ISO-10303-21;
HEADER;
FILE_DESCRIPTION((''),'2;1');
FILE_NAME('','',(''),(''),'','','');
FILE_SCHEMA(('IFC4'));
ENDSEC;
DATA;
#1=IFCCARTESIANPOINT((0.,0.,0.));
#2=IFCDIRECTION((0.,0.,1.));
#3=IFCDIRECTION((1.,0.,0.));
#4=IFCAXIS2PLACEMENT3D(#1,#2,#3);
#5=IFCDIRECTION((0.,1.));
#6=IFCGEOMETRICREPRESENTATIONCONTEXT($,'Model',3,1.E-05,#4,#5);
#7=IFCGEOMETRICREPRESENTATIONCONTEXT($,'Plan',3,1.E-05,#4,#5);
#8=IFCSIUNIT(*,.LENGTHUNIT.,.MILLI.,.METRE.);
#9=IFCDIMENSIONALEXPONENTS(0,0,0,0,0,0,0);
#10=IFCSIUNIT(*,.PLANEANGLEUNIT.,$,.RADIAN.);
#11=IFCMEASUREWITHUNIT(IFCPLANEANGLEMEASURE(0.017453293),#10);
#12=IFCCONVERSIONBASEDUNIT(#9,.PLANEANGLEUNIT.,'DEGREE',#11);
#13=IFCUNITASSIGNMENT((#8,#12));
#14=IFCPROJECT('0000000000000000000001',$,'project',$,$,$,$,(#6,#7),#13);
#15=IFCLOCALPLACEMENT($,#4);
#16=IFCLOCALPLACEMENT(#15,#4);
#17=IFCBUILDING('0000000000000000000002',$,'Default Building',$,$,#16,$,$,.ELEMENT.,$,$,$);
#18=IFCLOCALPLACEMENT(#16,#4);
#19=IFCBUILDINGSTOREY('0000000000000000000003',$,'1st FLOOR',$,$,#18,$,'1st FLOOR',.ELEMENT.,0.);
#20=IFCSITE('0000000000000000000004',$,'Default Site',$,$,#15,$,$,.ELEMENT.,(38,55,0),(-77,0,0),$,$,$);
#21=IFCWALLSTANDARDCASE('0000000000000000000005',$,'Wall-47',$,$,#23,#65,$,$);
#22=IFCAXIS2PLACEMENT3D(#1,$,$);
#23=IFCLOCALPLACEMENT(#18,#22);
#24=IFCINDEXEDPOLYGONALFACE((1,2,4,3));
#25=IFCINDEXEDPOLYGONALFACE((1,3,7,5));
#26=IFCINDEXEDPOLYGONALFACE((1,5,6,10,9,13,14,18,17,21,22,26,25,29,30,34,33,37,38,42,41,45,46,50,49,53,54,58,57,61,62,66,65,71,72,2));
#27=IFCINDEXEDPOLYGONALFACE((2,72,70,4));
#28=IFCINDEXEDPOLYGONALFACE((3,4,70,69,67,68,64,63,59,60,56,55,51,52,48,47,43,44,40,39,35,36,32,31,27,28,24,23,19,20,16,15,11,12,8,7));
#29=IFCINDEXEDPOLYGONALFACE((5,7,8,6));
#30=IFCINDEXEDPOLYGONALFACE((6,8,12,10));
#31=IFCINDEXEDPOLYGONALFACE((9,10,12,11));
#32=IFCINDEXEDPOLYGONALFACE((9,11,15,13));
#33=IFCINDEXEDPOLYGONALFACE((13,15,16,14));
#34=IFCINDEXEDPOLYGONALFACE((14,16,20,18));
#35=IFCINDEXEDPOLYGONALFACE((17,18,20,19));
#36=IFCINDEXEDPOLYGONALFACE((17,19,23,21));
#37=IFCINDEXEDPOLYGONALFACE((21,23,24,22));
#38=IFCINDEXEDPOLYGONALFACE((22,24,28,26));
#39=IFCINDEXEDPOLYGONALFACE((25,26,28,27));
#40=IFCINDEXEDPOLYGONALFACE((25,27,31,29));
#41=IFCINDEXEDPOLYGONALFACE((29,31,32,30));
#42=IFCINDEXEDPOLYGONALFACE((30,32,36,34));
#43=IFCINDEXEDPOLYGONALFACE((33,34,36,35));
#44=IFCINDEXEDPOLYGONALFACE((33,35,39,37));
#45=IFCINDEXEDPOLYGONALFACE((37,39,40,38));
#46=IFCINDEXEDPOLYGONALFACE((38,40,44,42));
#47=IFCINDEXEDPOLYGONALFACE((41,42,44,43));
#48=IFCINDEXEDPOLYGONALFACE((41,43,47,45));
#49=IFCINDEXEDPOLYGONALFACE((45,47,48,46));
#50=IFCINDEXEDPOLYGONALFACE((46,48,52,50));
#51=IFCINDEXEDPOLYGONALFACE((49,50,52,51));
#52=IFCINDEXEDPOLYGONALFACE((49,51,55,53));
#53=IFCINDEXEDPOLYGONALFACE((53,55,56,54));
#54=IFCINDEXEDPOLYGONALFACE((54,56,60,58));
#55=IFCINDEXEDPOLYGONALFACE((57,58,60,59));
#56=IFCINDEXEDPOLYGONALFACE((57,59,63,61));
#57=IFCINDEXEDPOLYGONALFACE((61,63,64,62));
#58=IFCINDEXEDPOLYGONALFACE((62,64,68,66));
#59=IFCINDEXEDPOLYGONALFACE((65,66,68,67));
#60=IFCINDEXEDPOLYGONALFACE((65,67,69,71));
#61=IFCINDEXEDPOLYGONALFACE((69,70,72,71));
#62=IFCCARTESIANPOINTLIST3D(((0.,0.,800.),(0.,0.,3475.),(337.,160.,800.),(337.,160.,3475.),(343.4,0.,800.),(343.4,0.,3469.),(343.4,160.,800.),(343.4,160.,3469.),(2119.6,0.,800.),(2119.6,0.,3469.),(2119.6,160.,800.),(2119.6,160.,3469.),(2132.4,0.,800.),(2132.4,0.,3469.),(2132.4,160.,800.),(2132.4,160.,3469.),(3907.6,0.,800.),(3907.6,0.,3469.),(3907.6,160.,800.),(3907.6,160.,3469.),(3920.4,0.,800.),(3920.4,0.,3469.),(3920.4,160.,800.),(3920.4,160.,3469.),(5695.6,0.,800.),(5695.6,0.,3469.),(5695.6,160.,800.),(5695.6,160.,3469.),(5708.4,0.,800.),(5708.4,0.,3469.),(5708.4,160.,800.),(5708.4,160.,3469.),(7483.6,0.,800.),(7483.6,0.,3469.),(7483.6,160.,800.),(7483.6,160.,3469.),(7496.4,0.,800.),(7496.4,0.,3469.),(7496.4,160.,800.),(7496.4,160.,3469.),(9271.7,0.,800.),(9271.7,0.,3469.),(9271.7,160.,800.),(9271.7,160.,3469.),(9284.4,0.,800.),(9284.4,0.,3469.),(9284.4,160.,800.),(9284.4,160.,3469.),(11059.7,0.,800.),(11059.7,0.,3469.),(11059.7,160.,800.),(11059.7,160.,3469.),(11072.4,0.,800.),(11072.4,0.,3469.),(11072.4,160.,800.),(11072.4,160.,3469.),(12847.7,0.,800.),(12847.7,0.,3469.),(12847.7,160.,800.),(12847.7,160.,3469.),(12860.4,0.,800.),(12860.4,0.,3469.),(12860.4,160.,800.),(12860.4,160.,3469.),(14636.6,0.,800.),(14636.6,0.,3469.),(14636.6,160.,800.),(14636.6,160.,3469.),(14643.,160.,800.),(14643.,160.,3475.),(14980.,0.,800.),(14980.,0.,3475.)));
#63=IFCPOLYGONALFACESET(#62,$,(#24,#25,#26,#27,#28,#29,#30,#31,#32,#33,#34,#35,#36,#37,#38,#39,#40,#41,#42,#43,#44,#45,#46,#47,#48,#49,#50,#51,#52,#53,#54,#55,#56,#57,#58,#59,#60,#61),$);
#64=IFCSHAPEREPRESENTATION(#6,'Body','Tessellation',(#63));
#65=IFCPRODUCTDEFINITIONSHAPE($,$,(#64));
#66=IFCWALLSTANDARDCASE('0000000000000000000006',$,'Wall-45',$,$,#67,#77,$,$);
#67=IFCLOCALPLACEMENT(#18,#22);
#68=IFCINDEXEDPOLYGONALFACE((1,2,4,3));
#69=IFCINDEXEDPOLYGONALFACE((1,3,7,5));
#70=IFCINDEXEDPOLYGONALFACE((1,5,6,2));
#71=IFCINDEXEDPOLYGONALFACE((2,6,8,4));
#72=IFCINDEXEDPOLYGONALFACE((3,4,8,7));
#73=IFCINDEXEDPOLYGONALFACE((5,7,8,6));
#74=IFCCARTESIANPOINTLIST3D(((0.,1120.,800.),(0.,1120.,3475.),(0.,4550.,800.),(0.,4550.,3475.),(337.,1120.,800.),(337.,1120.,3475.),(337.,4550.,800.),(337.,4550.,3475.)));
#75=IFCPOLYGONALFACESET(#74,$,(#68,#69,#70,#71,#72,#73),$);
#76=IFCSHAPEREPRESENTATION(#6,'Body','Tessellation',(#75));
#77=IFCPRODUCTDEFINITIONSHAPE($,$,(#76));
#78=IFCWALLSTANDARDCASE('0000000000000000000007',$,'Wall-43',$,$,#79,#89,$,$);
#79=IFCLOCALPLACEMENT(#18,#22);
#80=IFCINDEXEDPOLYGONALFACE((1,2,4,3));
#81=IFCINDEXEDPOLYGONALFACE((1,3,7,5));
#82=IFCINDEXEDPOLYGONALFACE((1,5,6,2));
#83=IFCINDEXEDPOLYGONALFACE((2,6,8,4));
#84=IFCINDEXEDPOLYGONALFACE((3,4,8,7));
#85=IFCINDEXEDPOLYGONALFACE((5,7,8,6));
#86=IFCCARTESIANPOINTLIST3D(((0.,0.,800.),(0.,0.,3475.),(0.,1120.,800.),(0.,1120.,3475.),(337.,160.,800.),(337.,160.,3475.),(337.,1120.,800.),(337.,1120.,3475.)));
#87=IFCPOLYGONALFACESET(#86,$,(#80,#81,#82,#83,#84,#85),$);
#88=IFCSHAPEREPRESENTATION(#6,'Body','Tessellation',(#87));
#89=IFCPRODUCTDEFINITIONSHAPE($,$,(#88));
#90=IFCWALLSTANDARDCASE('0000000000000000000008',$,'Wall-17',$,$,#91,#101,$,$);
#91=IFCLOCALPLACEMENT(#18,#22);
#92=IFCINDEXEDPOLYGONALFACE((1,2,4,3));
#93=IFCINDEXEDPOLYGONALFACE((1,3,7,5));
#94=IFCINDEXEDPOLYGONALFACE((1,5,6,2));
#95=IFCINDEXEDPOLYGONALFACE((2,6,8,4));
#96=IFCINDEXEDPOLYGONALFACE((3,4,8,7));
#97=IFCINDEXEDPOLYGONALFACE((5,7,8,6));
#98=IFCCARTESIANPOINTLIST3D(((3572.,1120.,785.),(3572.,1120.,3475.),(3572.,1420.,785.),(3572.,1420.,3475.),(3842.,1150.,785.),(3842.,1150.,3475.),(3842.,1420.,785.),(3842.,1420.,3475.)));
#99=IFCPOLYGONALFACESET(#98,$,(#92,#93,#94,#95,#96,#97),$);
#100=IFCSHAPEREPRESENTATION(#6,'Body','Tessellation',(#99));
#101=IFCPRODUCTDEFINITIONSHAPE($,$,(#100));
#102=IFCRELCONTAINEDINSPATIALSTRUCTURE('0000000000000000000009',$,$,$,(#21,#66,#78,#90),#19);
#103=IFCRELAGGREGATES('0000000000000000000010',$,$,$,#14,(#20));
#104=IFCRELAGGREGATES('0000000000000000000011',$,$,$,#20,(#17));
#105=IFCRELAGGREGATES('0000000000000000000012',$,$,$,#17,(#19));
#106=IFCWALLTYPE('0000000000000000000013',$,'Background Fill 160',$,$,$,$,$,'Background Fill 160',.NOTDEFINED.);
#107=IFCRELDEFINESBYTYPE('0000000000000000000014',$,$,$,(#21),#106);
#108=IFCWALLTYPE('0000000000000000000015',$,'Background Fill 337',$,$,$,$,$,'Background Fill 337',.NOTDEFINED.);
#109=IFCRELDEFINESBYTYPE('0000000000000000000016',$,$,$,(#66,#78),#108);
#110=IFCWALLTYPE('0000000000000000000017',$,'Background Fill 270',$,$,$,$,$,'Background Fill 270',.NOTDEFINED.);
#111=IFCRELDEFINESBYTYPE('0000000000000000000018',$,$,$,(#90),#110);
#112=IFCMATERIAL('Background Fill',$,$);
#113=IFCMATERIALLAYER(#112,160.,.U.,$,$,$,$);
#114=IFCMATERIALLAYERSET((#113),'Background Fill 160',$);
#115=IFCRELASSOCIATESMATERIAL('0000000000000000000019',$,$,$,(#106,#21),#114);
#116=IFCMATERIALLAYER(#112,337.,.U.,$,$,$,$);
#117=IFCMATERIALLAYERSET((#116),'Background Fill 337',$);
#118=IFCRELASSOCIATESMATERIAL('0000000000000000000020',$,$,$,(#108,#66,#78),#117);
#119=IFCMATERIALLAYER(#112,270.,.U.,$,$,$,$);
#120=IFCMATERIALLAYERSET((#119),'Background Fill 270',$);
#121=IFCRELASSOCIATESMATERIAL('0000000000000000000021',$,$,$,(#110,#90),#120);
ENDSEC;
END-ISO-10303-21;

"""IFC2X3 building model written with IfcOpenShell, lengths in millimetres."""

from ifc_helpers import new_model, entity, si_unit, converted_unit, direction, frame, origin_with_axes, place, context, project, spatial, polyline, outline, extrude, material, layer, layer_set, layer_usage, type_object, element, save


model = new_model("IFC2X3")

# Units and contexts
model_context = context("Model", 3, precision=1e-05, world=origin_with_axes(), true_north=direction((0.0, 1.0)))
plan_context = context("Plan", 3, precision=1e-05, world=origin_with_axes(), true_north=direction((0.0, 1.0)))
ifc_project = project(units=[si_unit("LENGTHUNIT", "METRE", prefix="MILLI"), converted_unit("PLANEANGLEUNIT", "DEGREE", entity("IfcPlaneAngleMeasure", 0.017453293), si_unit("PLANEANGLEUNIT", "RADIAN"), dimensions=[0, 0, 0, 0, 0, 0, 0])], contexts=[model_context, plan_context])

# Site, building, storey
site_placement = place(None, origin_with_axes())
site = spatial("IfcSite", under=ifc_project, at=site_placement, Name="Default Site", CompositionType="ELEMENT", RefLatitude=(38, 55, 0), RefLongitude=(-77, 0, 0))
building_placement = place(site_placement, origin_with_axes())
building = spatial("IfcBuilding", under=site, at=building_placement, Name="Default Building", CompositionType="ELEMENT")
storey_placement = place(building_placement, origin_with_axes())
storey = spatial("IfcBuildingStorey", under=building, at=storey_placement, Name="1st FLOOR", LongName="1st FLOOR", CompositionType="ELEMENT", Elevation=0.0)

# Shared definitions
ifc_material = material(Name="Background Fill")

# Wall, openings
ifc_layer_1 = layer(ifc_material, 160.0, ventilated="UNKNOWN")
ifc_layer_set_1 = layer_set([ifc_layer_1], Name="Background Fill 160")
ifc_layer_usage_1 = layer_usage(ifc_layer_set_1, "AXIS2", "POSITIVE", 0.0)
wall_type_1 = type_object("IfcWallType", Name="Background Fill 160", ElementType="Background Fill 160", PredefinedType="NOTDEFINED", material=ifc_layer_set_1)
wall_1_placement = place(storey_placement, frame((0.0, 0.0, 800.0), z_axis=(0.0, 0.0, 1.0), x_axis=(1.0, 0.0, 0.0)))
wall_1 = element("IfcWallStandardCase", 1, at=wall_1_placement, inside=storey, type_object=wall_type_1, material=ifc_layer_usage_1, Name="Wall-47", context=model_context, shape_type="SweptSolid", body=[
    extrude(outline(polyline([(0.0, 0.0), (14980.0, 0.0), (14643.0, 160.0), (337.0, 160.0), (0.0, 0.0)])), origin_with_axes(), (0.0, 0.0, 1.0), 2675.0),
])
opening_1_placement = place(wall_1_placement, frame((13748.5, 0.0, 0.0), z_axis=(0.0, 0.0, 1.0), x_axis=(1.0, 0.0, 0.0)))
element("IfcOpeningElement", 2, at=opening_1_placement, cuts=wall_1, ObjectType="Opening", context=model_context, shape_type="SweptSolid", body=[
    extrude(outline(polyline([(-888.1, 0.0), (888.1, 0.0), (888.1, 2669.0), (-888.1, 2669.0), (-888.1, 0.0)])), frame((0.0, 0.0, 0.0), z_axis=(0.0, 1.0, 0.0), x_axis=(-1.0, 0.0, 0.0)), (0.0, 0.0, 1.0), 160.0),
])
opening_2_placement = place(wall_1_placement, frame((3020.0, 0.0, 0.0), z_axis=(0.0, 0.0, 1.0), x_axis=(1.0, 0.0, 0.0)))
element("IfcOpeningElement", 3, at=opening_2_placement, cuts=wall_1, ObjectType="Opening", context=model_context, shape_type="SweptSolid", body=[
    extrude(outline(polyline([(-887.6, 0.0), (887.6, 0.0), (887.6, 2669.0), (-887.6, 2669.0), (-887.6, 0.0)])), frame((0.0, 0.0, 0.0), z_axis=(0.0, 1.0, 0.0), x_axis=(-1.0, 0.0, 0.0)), (0.0, 0.0, 1.0), 160.0),
])
opening_3_placement = place(wall_1_placement, frame((11960.0, 0.0, 0.0), z_axis=(0.0, 0.0, 1.0), x_axis=(1.0, 0.0, 0.0)))
element("IfcOpeningElement", 4, at=opening_3_placement, cuts=wall_1, ObjectType="Opening", context=model_context, shape_type="SweptSolid", body=[
    extrude(outline(polyline([(-887.6, 0.0), (887.6, 0.0), (887.6, 2669.0), (-887.6, 2669.0), (-887.6, 0.0)])), frame((0.0, 0.0, 0.0), z_axis=(0.0, 1.0, 0.0), x_axis=(-1.0, 0.0, 0.0)), (0.0, 0.0, 1.0), 160.0),
])
opening_4_placement = place(wall_1_placement, frame((6596.0, 0.0, 0.0), z_axis=(0.0, 0.0, 1.0), x_axis=(1.0, 0.0, 0.0)))
element("IfcOpeningElement", 5, at=opening_4_placement, cuts=wall_1, ObjectType="Opening", context=model_context, shape_type="SweptSolid", body=[
    extrude(outline(polyline([(-887.6, 0.0), (887.6, 0.0), (887.6, 2669.0), (-887.6, 2669.0), (-887.6, 0.0)])), frame((0.0, 0.0, 0.0), z_axis=(0.0, 1.0, 0.0), x_axis=(-1.0, 0.0, 0.0)), (0.0, 0.0, 1.0), 160.0),
])
opening_5_placement = place(wall_1_placement, frame((10172.0, 0.0, 0.0), z_axis=(0.0, 0.0, 1.0), x_axis=(1.0, 0.0, 0.0)))
element("IfcOpeningElement", 6, at=opening_5_placement, cuts=wall_1, ObjectType="Opening", context=model_context, shape_type="SweptSolid", body=[
    extrude(outline(polyline([(-887.6, 0.0), (887.6, 0.0), (887.6, 2669.0), (-887.6, 2669.0), (-887.6, 0.0)])), frame((0.0, 0.0, 0.0), z_axis=(0.0, 1.0, 0.0), x_axis=(-1.0, 0.0, 0.0)), (0.0, 0.0, 1.0), 160.0),
])
opening_6_placement = place(wall_1_placement, frame((8384.0, 0.0, 0.0), z_axis=(0.0, 0.0, 1.0), x_axis=(1.0, 0.0, 0.0)))
element("IfcOpeningElement", 7, at=opening_6_placement, cuts=wall_1, ObjectType="Opening", context=model_context, shape_type="SweptSolid", body=[
    extrude(outline(polyline([(-887.6, 0.0), (887.6, 0.0), (887.6, 2669.0), (-887.6, 2669.0), (-887.6, 0.0)])), frame((0.0, 0.0, 0.0), z_axis=(0.0, 1.0, 0.0), x_axis=(-1.0, 0.0, 0.0)), (0.0, 0.0, 1.0), 160.0),
])
opening_7_placement = place(wall_1_placement, frame((4808.0, 0.0, 0.0), z_axis=(0.0, 0.0, 1.0), x_axis=(1.0, 0.0, 0.0)))
element("IfcOpeningElement", 8, at=opening_7_placement, cuts=wall_1, ObjectType="Opening", context=model_context, shape_type="SweptSolid", body=[
    extrude(outline(polyline([(-887.6, 0.0), (887.6, 0.0), (887.6, 2669.0), (-887.6, 2669.0), (-887.6, 0.0)])), frame((0.0, 0.0, 0.0), z_axis=(0.0, 1.0, 0.0), x_axis=(-1.0, 0.0, 0.0)), (0.0, 0.0, 1.0), 160.0),
])
opening_8_placement = place(wall_1_placement, frame((1231.5, 0.0, 0.0), z_axis=(0.0, 0.0, 1.0), x_axis=(1.0, 0.0, 0.0)))
element("IfcOpeningElement", 9, at=opening_8_placement, cuts=wall_1, ObjectType="Opening", context=model_context, shape_type="SweptSolid", body=[
    extrude(outline(polyline([(-888.1, 0.0), (888.1, 0.0), (888.1, 2669.0), (-888.1, 2669.0), (-888.1, 0.0)])), frame((0.0, 0.0, 0.0), z_axis=(0.0, 1.0, 0.0), x_axis=(-1.0, 0.0, 0.0)), (0.0, 0.0, 1.0), 160.0),
])

# Walls
ifc_layer_2 = layer(ifc_material, 337.0, ventilated="UNKNOWN")
ifc_layer_set_2 = layer_set([ifc_layer_2], Name="Background Fill 337")
ifc_layer_usage_2 = layer_usage(ifc_layer_set_2, "AXIS2", "NEGATIVE", 0.0)
wall_type_2 = type_object("IfcWallType", Name="Background Fill 337", ElementType="Background Fill 337", PredefinedType="NOTDEFINED", material=ifc_layer_set_2)
wall_2_placement = place(storey_placement, frame((0.0, 1120.0, 800.0), z_axis=(0.0, 0.0, 1.0), x_axis=(0.0, 1.0, 0.0)))
element("IfcWallStandardCase", 10, at=wall_2_placement, inside=storey, type_object=wall_type_2, material=ifc_layer_usage_2, Name="Wall-45", context=model_context, shape_type="SweptSolid", body=[
    extrude(outline(polyline([(0.0, -337.0), (3430.0, -337.0), (3430.0, 0.0), (0.0, 0.0), (0.0, -337.0)])), origin_with_axes(), (0.0, 0.0, 1.0), 2675.0),
])
ifc_layer_usage_3 = layer_usage(ifc_layer_set_2, "AXIS2", "NEGATIVE", 0.0)
wall_3_placement = place(storey_placement, frame((0.0, 0.0, 800.0), z_axis=(0.0, 0.0, 1.0), x_axis=(0.0, 1.0, 0.0)))
element("IfcWallStandardCase", 11, at=wall_3_placement, inside=storey, type_object=wall_type_2, material=ifc_layer_usage_3, Name="Wall-43", context=model_context, shape_type="SweptSolid", body=[
    extrude(outline(polyline([(160.0, -337.0), (1120.0, -337.0), (1120.0, 0.0), (0.0, 0.0), (160.0, -337.0)])), origin_with_axes(), (0.0, 0.0, 1.0), 2675.0),
])
ifc_layer_3 = layer(ifc_material, 270.0, ventilated="UNKNOWN")
ifc_layer_set_3 = layer_set([ifc_layer_3], Name="Background Fill 270")
ifc_layer_usage_4 = layer_usage(ifc_layer_set_3, "AXIS2", "NEGATIVE", 0.0)
wall_type_3 = type_object("IfcWallType", Name="Background Fill 270", ElementType="Background Fill 270", PredefinedType="NOTDEFINED", material=ifc_layer_set_3)
wall_4_placement = place(storey_placement, frame((3572.0, 1120.0, 785.0), z_axis=(0.0, 0.0, 1.0), x_axis=(0.0, 1.0, 0.0)))
element("IfcWallStandardCase", 12, at=wall_4_placement, inside=storey, type_object=wall_type_3, material=ifc_layer_usage_4, Name="Wall-17", context=model_context, shape_type="SweptSolid", body=[
    extrude(outline(polyline([(30.0, -270.0), (300.0, -270.0), (300.0, 0.0), (0.0, 0.0), (30.0, -270.0)])), origin_with_axes(), (0.0, 0.0, 1.0), 2690.0),
])

save(model, "model.ifc")
